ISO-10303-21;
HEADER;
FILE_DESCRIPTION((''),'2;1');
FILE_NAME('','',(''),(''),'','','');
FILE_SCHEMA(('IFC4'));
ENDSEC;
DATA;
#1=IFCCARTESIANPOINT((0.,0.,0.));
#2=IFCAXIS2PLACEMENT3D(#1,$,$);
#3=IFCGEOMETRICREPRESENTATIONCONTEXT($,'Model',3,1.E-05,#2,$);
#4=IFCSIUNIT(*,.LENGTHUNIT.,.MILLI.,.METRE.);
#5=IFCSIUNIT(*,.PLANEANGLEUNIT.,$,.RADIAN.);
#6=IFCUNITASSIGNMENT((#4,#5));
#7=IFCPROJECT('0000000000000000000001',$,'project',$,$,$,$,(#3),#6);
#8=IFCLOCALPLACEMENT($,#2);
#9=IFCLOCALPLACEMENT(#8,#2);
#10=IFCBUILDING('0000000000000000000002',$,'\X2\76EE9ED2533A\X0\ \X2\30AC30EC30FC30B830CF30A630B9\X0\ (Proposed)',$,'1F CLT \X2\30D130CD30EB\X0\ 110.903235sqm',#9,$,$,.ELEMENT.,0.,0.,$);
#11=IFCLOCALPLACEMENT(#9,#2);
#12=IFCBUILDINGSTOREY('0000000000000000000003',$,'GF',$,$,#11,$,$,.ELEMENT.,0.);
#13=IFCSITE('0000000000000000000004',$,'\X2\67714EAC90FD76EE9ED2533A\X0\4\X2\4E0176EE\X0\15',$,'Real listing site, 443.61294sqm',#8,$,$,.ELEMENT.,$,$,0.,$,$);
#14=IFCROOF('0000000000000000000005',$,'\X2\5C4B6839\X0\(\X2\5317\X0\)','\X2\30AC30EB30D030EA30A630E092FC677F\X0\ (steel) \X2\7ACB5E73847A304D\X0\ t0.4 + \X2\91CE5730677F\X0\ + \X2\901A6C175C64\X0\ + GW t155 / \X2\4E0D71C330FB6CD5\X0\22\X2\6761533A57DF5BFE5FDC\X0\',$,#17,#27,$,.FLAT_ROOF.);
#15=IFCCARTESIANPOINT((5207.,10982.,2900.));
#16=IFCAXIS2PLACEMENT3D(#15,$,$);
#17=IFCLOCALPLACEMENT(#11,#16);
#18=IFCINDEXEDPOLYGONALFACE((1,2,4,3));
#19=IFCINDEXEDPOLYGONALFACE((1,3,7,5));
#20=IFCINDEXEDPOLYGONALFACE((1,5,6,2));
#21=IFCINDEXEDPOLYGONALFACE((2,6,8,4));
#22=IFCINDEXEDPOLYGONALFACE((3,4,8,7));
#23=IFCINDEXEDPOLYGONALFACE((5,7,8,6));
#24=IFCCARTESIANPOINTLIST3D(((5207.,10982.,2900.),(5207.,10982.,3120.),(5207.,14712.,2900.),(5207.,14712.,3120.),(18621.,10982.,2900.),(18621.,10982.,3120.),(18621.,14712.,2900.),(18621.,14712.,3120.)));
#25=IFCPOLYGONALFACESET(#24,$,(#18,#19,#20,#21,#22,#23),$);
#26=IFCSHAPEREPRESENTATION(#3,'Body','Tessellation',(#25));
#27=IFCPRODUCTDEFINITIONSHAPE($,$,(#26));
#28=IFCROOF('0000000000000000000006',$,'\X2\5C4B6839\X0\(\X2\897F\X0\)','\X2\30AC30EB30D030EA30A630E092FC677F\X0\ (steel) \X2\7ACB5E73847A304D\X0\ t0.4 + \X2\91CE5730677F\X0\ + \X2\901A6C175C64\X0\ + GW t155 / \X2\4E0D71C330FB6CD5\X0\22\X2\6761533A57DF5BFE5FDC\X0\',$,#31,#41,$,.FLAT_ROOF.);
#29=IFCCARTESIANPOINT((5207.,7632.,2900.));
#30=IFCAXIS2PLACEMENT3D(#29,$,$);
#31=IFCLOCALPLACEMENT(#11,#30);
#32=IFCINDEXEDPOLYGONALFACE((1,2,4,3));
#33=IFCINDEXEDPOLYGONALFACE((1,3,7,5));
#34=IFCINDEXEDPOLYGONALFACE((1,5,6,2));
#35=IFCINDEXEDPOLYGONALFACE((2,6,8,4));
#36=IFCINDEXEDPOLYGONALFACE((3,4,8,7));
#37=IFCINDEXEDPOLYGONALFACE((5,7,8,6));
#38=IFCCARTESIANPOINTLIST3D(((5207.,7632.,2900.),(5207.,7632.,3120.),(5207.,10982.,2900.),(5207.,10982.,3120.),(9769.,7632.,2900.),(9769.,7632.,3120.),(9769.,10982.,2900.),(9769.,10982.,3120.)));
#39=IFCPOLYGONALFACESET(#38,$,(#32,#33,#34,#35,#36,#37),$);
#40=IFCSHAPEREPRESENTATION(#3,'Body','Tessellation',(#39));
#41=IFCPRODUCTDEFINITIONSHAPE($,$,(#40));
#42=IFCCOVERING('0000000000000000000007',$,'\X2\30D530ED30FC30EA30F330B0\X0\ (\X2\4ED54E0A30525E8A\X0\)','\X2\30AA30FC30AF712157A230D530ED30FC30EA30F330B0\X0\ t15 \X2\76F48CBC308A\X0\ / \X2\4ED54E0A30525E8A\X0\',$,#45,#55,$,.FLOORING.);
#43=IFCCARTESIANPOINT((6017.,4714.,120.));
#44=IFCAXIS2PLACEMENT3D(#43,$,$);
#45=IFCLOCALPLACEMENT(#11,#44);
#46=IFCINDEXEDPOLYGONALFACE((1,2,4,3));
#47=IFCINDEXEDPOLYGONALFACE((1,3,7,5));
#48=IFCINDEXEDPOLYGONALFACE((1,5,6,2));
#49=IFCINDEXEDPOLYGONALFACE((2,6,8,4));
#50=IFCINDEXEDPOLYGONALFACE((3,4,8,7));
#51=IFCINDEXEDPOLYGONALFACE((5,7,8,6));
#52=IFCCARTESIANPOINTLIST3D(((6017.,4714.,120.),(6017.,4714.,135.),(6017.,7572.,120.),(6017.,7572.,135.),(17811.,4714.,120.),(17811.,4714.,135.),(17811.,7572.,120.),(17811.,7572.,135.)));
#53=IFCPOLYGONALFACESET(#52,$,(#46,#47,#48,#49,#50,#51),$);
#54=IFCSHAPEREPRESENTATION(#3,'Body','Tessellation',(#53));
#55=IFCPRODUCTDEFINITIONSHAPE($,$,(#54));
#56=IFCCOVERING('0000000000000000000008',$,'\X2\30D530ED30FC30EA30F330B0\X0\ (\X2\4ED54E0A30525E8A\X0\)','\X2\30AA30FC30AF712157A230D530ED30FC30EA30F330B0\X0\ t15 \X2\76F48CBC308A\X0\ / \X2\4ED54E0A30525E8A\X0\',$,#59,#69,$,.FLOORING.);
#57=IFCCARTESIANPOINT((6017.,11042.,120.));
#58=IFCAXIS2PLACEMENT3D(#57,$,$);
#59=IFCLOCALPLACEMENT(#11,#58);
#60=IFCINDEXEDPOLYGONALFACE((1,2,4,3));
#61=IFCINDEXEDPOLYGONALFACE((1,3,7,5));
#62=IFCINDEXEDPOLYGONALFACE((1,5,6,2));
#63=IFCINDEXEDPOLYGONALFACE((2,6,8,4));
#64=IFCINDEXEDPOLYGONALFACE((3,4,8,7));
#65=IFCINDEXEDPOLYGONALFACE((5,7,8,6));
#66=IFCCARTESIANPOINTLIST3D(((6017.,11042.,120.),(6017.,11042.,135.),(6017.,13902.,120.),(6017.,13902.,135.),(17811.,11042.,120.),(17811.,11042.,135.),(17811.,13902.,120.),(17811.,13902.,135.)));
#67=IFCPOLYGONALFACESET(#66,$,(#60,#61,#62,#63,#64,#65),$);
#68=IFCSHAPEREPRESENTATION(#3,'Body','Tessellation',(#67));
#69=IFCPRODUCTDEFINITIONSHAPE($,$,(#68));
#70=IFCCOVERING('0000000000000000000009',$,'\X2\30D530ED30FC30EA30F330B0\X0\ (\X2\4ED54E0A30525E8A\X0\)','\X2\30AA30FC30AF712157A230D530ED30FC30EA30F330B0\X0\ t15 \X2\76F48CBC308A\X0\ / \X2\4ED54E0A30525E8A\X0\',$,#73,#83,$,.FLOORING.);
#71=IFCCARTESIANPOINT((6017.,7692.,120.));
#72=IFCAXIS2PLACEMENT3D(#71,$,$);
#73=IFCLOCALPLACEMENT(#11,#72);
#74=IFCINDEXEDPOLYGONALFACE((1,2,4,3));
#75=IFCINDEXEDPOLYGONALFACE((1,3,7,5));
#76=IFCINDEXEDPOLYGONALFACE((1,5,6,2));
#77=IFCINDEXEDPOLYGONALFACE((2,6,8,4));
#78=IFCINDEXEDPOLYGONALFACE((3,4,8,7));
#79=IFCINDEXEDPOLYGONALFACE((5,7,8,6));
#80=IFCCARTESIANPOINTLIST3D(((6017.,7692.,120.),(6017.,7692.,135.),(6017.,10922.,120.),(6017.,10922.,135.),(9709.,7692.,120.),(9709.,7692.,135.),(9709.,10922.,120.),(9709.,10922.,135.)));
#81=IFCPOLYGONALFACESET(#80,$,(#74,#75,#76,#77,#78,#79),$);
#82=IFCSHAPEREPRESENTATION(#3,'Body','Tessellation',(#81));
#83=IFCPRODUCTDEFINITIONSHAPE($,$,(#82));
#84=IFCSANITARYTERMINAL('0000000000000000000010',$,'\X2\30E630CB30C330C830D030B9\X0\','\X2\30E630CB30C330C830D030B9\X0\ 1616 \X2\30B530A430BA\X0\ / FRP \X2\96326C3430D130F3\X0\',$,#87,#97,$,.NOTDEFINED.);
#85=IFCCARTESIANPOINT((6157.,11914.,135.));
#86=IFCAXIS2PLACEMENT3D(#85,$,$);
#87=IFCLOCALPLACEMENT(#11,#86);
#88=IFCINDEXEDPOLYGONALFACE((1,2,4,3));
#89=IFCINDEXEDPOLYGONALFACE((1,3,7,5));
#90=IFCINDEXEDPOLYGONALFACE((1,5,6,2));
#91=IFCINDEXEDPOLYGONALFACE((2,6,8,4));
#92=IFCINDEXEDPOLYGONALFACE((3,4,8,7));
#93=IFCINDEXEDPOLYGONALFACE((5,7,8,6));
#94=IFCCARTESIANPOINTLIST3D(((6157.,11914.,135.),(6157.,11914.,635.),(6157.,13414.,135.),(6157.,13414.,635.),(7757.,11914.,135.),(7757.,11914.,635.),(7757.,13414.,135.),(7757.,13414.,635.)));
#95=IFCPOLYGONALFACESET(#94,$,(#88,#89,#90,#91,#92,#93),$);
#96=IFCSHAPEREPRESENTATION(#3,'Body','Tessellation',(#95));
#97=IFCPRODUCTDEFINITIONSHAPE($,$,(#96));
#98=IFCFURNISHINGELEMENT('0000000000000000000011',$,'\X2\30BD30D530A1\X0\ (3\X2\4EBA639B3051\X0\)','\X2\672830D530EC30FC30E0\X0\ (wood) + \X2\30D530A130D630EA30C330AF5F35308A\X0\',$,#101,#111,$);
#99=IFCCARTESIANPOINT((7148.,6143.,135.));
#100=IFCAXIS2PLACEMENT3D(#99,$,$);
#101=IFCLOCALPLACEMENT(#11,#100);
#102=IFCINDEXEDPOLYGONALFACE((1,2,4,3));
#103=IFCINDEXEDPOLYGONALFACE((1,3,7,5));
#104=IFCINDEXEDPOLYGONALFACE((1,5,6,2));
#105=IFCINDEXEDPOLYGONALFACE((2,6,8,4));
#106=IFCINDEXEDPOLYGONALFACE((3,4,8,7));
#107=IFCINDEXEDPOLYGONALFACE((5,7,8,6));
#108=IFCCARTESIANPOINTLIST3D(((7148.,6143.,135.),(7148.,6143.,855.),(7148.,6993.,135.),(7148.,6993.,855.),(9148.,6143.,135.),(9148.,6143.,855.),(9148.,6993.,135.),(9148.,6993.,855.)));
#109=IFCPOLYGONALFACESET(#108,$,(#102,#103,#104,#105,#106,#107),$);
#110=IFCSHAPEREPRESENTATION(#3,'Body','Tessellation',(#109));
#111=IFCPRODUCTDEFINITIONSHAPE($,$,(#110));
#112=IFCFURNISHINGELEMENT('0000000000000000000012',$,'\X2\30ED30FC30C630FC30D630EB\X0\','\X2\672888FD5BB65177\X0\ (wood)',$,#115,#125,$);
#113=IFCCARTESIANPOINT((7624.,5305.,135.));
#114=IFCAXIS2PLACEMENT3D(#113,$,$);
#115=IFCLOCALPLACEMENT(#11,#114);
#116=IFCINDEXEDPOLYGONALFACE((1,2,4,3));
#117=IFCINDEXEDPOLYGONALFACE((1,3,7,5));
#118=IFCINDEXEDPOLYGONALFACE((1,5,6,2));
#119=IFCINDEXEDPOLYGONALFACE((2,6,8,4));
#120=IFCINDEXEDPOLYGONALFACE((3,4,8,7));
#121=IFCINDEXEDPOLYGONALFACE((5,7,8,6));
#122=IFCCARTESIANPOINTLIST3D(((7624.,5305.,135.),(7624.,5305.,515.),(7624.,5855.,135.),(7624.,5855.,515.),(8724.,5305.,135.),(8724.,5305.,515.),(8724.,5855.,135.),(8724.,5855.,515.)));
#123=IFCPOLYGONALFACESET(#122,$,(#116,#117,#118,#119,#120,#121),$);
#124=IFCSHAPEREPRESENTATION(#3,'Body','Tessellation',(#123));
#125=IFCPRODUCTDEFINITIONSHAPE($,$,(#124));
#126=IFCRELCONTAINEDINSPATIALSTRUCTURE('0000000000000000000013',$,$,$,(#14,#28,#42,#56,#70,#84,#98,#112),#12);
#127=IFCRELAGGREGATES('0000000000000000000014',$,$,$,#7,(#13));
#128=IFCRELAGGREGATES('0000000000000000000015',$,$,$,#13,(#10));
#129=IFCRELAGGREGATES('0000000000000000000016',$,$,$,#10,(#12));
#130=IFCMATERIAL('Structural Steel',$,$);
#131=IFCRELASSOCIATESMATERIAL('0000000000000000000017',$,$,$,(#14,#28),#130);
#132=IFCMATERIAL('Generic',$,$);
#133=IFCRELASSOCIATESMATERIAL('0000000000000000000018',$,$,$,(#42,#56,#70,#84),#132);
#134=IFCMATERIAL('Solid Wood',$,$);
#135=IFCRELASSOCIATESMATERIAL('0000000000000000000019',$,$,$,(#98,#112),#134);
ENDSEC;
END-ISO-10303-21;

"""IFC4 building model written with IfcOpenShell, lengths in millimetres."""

from ifc_helpers import new_model, si_unit, frame, frame_2d, origin, place, context, project, spatial, rectangle, extrude, material, element, save


model = new_model("IFC4")

# Units and contexts
model_context = context("Model", 3, precision=1e-05, world=origin())
ifc_project = project(units=[si_unit("LENGTHUNIT", "METRE", prefix="MILLI"), si_unit("PLANEANGLEUNIT", "RADIAN")], contexts=[model_context])

# Site, building, storey
site_placement = place(None, origin())
site = spatial("IfcSite", under=ifc_project, at=site_placement, Name="東京都目黒区4丁目15", ObjectType="Real listing site, 443.61294sqm", CompositionType="ELEMENT", RefElevation=0.0)
building_placement = place(site_placement, origin())
building = spatial("IfcBuilding", under=site, at=building_placement, Name="目黒区 ガレージハウス (Proposed)", ObjectType="1F CLT パネル 110.903235sqm", CompositionType="ELEMENT", ElevationOfRefHeight=0.0, ElevationOfTerrain=0.0)
storey_placement = place(building_placement, origin())
storey = spatial("IfcBuildingStorey", under=building, at=storey_placement, Name="GF", CompositionType="ELEMENT", Elevation=0.0)

# Shared definitions
ifc_material_1 = material(Name="Solid Wood")

# Roofs
ifc_material_2 = material(Name="Structural Steel")
roof_1_placement = place(storey_placement, frame((5207.0, 10982.0, 2900.0)))
element("IfcRoof", 1, at=roof_1_placement, inside=storey, material=ifc_material_2, Name="屋根(北)", Description="ガルバリウム鋼板 (steel) 立平葺き t0.4 + 野地板 + 通気層 + GW t155 / 不燃・法22条区域対応", PredefinedType="FLAT_ROOF", context=model_context, shape_type="SweptSolid", body=[
    extrude(rectangle(XDim=13414.0, YDim=3730.0, at=frame_2d((6707.0, 1865.0))), frame((5207.0, 10982.0, 2900.0)), (0.0, 0.0, 1.0), 220.0),
])
roof_2_placement = place(storey_placement, frame((5207.0, 7632.0, 2900.0)))
element("IfcRoof", 2, at=roof_2_placement, inside=storey, material=ifc_material_2, Name="屋根(西)", Description="ガルバリウム鋼板 (steel) 立平葺き t0.4 + 野地板 + 通気層 + GW t155 / 不燃・法22条区域対応", PredefinedType="FLAT_ROOF", context=model_context, shape_type="SweptSolid", body=[
    extrude(rectangle(XDim=4562.0, YDim=3350.0, at=frame_2d((2281.0, 1675.0))), frame((5207.0, 7632.0, 2900.0)), (0.0, 0.0, 1.0), 220.0),
])

# Coverings
ifc_material_3 = material(Name="Generic")
covering_1_placement = place(storey_placement, frame((6017.0, 4714.0, 120.0)))
element("IfcCovering", 3, at=covering_1_placement, inside=storey, material=ifc_material_3, Name="フローリング (仕上げ床)", Description="オーク無垢フローリング t15 直貼り / 仕上げ床", PredefinedType="FLOORING", context=model_context, shape_type="SweptSolid", body=[
    extrude(rectangle(XDim=11794.0, YDim=2858.0, at=frame_2d((5897.0, 1429.0))), frame((6017.0, 4714.0, 120.0)), (0.0, 0.0, 1.0), 15.0),
])
covering_2_placement = place(storey_placement, frame((6017.0, 11042.0, 120.0)))
element("IfcCovering", 4, at=covering_2_placement, inside=storey, material=ifc_material_3, Name="フローリング (仕上げ床)", Description="オーク無垢フローリング t15 直貼り / 仕上げ床", PredefinedType="FLOORING", context=model_context, shape_type="SweptSolid", body=[
    extrude(rectangle(XDim=11794.0, YDim=2860.0, at=frame_2d((5897.0, 1430.0))), frame((6017.0, 11042.0, 120.0)), (0.0, 0.0, 1.0), 15.0),
])
covering_3_placement = place(storey_placement, frame((6017.0, 7692.0, 120.0)))
element("IfcCovering", 5, at=covering_3_placement, inside=storey, material=ifc_material_3, Name="フローリング (仕上げ床)", Description="オーク無垢フローリング t15 直貼り / 仕上げ床", PredefinedType="FLOORING", context=model_context, shape_type="SweptSolid", body=[
    extrude(rectangle(XDim=3692.0, YDim=3230.0, at=frame_2d((1846.0, 1615.0))), frame((6017.0, 7692.0, 120.0)), (0.0, 0.0, 1.0), 15.0),
])

# Sanitary terminal
sanitary_terminal_placement = place(storey_placement, frame((6157.0, 11914.0, 135.0)))
element("IfcSanitaryTerminal", 6, at=sanitary_terminal_placement, inside=storey, material=ifc_material_3, Name="ユニットバス", Description="ユニットバス 1616 サイズ / FRP 防水パン", PredefinedType="NOTDEFINED", context=model_context, shape_type="SweptSolid", body=[
    extrude(rectangle(XDim=1600.0, YDim=1500.0, at=frame_2d((800.0, 750.0))), frame((6157.0, 11914.0, 135.0)), (0.0, 0.0, 1.0), 500.0),
])

# Furnishing elements
furnishing_1_placement = place(storey_placement, frame((7148.0, 6143.0, 135.0)))
element("IfcFurnishingElement", 7, at=furnishing_1_placement, inside=storey, material=ifc_material_1, Name="ソファ (3人掛け)", Description="木フレーム (wood) + ファブリック張り", context=model_context, shape_type="SweptSolid", body=[
    extrude(rectangle(XDim=2000.0, YDim=850.0, at=frame_2d((1000.0, 425.0))), frame((7148.0, 6143.0, 135.0)), (0.0, 0.0, 1.0), 720.0),
])
furnishing_2_placement = place(storey_placement, frame((7624.0, 5305.0, 135.0)))
element("IfcFurnishingElement", 8, at=furnishing_2_placement, inside=storey, material=ifc_material_1, Name="ローテーブル", Description="木製家具 (wood)", context=model_context, shape_type="SweptSolid", body=[
    extrude(rectangle(XDim=1100.0, YDim=550.0, at=frame_2d((550.0, 275.0))), frame((7624.0, 5305.0, 135.0)), (0.0, 0.0, 1.0), 380.0),
])

save(model, "model.ifc")
